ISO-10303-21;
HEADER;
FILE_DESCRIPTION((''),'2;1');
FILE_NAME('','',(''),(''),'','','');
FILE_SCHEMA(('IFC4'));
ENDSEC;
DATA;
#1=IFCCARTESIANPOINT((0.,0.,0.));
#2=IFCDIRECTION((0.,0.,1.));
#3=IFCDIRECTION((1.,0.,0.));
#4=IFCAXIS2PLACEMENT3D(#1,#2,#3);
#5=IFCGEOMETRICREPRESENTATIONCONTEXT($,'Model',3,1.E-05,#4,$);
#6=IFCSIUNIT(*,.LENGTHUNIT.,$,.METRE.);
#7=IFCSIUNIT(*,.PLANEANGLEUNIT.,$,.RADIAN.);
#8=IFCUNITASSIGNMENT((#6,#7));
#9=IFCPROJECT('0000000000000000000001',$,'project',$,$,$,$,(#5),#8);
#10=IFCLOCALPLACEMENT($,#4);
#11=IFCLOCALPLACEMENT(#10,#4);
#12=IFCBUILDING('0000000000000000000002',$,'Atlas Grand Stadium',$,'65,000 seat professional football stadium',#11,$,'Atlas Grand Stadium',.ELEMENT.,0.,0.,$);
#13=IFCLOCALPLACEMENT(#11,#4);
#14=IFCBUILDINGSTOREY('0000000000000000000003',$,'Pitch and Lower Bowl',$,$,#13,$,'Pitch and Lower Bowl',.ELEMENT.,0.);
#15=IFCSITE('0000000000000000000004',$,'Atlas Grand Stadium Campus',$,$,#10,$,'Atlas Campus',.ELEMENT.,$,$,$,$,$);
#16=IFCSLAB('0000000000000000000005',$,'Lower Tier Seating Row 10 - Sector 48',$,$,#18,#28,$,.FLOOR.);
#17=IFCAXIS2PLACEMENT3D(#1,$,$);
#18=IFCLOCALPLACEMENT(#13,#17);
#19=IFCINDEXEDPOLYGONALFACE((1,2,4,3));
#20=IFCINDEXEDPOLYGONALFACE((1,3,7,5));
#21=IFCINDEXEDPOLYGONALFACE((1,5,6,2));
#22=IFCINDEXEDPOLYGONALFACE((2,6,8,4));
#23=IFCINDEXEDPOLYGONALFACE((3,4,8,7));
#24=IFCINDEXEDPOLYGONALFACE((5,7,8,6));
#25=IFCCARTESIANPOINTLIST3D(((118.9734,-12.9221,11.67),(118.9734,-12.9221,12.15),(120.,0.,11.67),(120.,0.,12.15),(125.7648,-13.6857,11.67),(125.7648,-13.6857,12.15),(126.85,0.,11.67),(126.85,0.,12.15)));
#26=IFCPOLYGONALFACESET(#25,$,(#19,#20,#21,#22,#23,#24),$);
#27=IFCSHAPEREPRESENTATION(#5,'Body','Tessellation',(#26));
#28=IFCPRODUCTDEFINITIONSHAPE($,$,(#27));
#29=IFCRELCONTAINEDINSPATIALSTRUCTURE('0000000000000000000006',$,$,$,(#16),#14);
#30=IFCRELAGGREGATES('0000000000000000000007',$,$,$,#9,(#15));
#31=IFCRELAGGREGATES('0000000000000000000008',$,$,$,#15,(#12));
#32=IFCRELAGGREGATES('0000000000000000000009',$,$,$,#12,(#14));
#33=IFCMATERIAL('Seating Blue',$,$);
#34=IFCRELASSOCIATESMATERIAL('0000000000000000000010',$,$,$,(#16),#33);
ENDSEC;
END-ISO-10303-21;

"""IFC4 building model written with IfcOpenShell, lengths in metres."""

from ifc_helpers import new_model, si_unit, frame, origin_with_axes, place, context, project, spatial, polyline, outline, extrude, material, element, save


model = new_model("IFC4")

# Units and contexts
model_context = context("Model", 3, precision=1e-05, world=origin_with_axes())
ifc_project = project(units=[si_unit("LENGTHUNIT", "METRE"), si_unit("PLANEANGLEUNIT", "RADIAN")], contexts=[model_context])

# Site, building, storey
site_placement = place(None, origin_with_axes())
site = spatial("IfcSite", under=ifc_project, at=site_placement, Name="Atlas Grand Stadium Campus", LongName="Atlas Campus", CompositionType="ELEMENT")
building_placement = place(site_placement, origin_with_axes())
building = spatial("IfcBuilding", under=site, at=building_placement, Name="Atlas Grand Stadium", ObjectType="65,000 seat professional football stadium", LongName="Atlas Grand Stadium", CompositionType="ELEMENT", ElevationOfRefHeight=0.0, ElevationOfTerrain=0.0)
storey_placement = place(building_placement, origin_with_axes())
storey = spatial("IfcBuildingStorey", under=building, at=storey_placement, Name="Pitch and Lower Bowl", LongName="Pitch and Lower Bowl", CompositionType="ELEMENT", Elevation=0.0)

# Slab
ifc_material_1 = material(Name="Seating Blue")
slab_1_placement = place(storey_placement, frame((0.0, 0.0, 11.67), z_axis=(0.0, 0.0, 1.0), x_axis=(1.0, 0.0, 0.0)))
element("IfcSlab", 1, at=slab_1_placement, inside=storey, material=ifc_material_1, Name="Lower Tier Seating Row 10 - Sector 48", PredefinedType="FLOOR", context=model_context, shape_type="SweptSolid", body=[
    extrude(outline(polyline([(125.7648, -13.6857), (126.85, 0.0), (120.0, 0.0), (118.9734, -12.9221), (125.7648, -13.6857)])), origin_with_axes(), (0.0, 0.0, 1.0), 0.48),
])

save(model, "model.ifc")
